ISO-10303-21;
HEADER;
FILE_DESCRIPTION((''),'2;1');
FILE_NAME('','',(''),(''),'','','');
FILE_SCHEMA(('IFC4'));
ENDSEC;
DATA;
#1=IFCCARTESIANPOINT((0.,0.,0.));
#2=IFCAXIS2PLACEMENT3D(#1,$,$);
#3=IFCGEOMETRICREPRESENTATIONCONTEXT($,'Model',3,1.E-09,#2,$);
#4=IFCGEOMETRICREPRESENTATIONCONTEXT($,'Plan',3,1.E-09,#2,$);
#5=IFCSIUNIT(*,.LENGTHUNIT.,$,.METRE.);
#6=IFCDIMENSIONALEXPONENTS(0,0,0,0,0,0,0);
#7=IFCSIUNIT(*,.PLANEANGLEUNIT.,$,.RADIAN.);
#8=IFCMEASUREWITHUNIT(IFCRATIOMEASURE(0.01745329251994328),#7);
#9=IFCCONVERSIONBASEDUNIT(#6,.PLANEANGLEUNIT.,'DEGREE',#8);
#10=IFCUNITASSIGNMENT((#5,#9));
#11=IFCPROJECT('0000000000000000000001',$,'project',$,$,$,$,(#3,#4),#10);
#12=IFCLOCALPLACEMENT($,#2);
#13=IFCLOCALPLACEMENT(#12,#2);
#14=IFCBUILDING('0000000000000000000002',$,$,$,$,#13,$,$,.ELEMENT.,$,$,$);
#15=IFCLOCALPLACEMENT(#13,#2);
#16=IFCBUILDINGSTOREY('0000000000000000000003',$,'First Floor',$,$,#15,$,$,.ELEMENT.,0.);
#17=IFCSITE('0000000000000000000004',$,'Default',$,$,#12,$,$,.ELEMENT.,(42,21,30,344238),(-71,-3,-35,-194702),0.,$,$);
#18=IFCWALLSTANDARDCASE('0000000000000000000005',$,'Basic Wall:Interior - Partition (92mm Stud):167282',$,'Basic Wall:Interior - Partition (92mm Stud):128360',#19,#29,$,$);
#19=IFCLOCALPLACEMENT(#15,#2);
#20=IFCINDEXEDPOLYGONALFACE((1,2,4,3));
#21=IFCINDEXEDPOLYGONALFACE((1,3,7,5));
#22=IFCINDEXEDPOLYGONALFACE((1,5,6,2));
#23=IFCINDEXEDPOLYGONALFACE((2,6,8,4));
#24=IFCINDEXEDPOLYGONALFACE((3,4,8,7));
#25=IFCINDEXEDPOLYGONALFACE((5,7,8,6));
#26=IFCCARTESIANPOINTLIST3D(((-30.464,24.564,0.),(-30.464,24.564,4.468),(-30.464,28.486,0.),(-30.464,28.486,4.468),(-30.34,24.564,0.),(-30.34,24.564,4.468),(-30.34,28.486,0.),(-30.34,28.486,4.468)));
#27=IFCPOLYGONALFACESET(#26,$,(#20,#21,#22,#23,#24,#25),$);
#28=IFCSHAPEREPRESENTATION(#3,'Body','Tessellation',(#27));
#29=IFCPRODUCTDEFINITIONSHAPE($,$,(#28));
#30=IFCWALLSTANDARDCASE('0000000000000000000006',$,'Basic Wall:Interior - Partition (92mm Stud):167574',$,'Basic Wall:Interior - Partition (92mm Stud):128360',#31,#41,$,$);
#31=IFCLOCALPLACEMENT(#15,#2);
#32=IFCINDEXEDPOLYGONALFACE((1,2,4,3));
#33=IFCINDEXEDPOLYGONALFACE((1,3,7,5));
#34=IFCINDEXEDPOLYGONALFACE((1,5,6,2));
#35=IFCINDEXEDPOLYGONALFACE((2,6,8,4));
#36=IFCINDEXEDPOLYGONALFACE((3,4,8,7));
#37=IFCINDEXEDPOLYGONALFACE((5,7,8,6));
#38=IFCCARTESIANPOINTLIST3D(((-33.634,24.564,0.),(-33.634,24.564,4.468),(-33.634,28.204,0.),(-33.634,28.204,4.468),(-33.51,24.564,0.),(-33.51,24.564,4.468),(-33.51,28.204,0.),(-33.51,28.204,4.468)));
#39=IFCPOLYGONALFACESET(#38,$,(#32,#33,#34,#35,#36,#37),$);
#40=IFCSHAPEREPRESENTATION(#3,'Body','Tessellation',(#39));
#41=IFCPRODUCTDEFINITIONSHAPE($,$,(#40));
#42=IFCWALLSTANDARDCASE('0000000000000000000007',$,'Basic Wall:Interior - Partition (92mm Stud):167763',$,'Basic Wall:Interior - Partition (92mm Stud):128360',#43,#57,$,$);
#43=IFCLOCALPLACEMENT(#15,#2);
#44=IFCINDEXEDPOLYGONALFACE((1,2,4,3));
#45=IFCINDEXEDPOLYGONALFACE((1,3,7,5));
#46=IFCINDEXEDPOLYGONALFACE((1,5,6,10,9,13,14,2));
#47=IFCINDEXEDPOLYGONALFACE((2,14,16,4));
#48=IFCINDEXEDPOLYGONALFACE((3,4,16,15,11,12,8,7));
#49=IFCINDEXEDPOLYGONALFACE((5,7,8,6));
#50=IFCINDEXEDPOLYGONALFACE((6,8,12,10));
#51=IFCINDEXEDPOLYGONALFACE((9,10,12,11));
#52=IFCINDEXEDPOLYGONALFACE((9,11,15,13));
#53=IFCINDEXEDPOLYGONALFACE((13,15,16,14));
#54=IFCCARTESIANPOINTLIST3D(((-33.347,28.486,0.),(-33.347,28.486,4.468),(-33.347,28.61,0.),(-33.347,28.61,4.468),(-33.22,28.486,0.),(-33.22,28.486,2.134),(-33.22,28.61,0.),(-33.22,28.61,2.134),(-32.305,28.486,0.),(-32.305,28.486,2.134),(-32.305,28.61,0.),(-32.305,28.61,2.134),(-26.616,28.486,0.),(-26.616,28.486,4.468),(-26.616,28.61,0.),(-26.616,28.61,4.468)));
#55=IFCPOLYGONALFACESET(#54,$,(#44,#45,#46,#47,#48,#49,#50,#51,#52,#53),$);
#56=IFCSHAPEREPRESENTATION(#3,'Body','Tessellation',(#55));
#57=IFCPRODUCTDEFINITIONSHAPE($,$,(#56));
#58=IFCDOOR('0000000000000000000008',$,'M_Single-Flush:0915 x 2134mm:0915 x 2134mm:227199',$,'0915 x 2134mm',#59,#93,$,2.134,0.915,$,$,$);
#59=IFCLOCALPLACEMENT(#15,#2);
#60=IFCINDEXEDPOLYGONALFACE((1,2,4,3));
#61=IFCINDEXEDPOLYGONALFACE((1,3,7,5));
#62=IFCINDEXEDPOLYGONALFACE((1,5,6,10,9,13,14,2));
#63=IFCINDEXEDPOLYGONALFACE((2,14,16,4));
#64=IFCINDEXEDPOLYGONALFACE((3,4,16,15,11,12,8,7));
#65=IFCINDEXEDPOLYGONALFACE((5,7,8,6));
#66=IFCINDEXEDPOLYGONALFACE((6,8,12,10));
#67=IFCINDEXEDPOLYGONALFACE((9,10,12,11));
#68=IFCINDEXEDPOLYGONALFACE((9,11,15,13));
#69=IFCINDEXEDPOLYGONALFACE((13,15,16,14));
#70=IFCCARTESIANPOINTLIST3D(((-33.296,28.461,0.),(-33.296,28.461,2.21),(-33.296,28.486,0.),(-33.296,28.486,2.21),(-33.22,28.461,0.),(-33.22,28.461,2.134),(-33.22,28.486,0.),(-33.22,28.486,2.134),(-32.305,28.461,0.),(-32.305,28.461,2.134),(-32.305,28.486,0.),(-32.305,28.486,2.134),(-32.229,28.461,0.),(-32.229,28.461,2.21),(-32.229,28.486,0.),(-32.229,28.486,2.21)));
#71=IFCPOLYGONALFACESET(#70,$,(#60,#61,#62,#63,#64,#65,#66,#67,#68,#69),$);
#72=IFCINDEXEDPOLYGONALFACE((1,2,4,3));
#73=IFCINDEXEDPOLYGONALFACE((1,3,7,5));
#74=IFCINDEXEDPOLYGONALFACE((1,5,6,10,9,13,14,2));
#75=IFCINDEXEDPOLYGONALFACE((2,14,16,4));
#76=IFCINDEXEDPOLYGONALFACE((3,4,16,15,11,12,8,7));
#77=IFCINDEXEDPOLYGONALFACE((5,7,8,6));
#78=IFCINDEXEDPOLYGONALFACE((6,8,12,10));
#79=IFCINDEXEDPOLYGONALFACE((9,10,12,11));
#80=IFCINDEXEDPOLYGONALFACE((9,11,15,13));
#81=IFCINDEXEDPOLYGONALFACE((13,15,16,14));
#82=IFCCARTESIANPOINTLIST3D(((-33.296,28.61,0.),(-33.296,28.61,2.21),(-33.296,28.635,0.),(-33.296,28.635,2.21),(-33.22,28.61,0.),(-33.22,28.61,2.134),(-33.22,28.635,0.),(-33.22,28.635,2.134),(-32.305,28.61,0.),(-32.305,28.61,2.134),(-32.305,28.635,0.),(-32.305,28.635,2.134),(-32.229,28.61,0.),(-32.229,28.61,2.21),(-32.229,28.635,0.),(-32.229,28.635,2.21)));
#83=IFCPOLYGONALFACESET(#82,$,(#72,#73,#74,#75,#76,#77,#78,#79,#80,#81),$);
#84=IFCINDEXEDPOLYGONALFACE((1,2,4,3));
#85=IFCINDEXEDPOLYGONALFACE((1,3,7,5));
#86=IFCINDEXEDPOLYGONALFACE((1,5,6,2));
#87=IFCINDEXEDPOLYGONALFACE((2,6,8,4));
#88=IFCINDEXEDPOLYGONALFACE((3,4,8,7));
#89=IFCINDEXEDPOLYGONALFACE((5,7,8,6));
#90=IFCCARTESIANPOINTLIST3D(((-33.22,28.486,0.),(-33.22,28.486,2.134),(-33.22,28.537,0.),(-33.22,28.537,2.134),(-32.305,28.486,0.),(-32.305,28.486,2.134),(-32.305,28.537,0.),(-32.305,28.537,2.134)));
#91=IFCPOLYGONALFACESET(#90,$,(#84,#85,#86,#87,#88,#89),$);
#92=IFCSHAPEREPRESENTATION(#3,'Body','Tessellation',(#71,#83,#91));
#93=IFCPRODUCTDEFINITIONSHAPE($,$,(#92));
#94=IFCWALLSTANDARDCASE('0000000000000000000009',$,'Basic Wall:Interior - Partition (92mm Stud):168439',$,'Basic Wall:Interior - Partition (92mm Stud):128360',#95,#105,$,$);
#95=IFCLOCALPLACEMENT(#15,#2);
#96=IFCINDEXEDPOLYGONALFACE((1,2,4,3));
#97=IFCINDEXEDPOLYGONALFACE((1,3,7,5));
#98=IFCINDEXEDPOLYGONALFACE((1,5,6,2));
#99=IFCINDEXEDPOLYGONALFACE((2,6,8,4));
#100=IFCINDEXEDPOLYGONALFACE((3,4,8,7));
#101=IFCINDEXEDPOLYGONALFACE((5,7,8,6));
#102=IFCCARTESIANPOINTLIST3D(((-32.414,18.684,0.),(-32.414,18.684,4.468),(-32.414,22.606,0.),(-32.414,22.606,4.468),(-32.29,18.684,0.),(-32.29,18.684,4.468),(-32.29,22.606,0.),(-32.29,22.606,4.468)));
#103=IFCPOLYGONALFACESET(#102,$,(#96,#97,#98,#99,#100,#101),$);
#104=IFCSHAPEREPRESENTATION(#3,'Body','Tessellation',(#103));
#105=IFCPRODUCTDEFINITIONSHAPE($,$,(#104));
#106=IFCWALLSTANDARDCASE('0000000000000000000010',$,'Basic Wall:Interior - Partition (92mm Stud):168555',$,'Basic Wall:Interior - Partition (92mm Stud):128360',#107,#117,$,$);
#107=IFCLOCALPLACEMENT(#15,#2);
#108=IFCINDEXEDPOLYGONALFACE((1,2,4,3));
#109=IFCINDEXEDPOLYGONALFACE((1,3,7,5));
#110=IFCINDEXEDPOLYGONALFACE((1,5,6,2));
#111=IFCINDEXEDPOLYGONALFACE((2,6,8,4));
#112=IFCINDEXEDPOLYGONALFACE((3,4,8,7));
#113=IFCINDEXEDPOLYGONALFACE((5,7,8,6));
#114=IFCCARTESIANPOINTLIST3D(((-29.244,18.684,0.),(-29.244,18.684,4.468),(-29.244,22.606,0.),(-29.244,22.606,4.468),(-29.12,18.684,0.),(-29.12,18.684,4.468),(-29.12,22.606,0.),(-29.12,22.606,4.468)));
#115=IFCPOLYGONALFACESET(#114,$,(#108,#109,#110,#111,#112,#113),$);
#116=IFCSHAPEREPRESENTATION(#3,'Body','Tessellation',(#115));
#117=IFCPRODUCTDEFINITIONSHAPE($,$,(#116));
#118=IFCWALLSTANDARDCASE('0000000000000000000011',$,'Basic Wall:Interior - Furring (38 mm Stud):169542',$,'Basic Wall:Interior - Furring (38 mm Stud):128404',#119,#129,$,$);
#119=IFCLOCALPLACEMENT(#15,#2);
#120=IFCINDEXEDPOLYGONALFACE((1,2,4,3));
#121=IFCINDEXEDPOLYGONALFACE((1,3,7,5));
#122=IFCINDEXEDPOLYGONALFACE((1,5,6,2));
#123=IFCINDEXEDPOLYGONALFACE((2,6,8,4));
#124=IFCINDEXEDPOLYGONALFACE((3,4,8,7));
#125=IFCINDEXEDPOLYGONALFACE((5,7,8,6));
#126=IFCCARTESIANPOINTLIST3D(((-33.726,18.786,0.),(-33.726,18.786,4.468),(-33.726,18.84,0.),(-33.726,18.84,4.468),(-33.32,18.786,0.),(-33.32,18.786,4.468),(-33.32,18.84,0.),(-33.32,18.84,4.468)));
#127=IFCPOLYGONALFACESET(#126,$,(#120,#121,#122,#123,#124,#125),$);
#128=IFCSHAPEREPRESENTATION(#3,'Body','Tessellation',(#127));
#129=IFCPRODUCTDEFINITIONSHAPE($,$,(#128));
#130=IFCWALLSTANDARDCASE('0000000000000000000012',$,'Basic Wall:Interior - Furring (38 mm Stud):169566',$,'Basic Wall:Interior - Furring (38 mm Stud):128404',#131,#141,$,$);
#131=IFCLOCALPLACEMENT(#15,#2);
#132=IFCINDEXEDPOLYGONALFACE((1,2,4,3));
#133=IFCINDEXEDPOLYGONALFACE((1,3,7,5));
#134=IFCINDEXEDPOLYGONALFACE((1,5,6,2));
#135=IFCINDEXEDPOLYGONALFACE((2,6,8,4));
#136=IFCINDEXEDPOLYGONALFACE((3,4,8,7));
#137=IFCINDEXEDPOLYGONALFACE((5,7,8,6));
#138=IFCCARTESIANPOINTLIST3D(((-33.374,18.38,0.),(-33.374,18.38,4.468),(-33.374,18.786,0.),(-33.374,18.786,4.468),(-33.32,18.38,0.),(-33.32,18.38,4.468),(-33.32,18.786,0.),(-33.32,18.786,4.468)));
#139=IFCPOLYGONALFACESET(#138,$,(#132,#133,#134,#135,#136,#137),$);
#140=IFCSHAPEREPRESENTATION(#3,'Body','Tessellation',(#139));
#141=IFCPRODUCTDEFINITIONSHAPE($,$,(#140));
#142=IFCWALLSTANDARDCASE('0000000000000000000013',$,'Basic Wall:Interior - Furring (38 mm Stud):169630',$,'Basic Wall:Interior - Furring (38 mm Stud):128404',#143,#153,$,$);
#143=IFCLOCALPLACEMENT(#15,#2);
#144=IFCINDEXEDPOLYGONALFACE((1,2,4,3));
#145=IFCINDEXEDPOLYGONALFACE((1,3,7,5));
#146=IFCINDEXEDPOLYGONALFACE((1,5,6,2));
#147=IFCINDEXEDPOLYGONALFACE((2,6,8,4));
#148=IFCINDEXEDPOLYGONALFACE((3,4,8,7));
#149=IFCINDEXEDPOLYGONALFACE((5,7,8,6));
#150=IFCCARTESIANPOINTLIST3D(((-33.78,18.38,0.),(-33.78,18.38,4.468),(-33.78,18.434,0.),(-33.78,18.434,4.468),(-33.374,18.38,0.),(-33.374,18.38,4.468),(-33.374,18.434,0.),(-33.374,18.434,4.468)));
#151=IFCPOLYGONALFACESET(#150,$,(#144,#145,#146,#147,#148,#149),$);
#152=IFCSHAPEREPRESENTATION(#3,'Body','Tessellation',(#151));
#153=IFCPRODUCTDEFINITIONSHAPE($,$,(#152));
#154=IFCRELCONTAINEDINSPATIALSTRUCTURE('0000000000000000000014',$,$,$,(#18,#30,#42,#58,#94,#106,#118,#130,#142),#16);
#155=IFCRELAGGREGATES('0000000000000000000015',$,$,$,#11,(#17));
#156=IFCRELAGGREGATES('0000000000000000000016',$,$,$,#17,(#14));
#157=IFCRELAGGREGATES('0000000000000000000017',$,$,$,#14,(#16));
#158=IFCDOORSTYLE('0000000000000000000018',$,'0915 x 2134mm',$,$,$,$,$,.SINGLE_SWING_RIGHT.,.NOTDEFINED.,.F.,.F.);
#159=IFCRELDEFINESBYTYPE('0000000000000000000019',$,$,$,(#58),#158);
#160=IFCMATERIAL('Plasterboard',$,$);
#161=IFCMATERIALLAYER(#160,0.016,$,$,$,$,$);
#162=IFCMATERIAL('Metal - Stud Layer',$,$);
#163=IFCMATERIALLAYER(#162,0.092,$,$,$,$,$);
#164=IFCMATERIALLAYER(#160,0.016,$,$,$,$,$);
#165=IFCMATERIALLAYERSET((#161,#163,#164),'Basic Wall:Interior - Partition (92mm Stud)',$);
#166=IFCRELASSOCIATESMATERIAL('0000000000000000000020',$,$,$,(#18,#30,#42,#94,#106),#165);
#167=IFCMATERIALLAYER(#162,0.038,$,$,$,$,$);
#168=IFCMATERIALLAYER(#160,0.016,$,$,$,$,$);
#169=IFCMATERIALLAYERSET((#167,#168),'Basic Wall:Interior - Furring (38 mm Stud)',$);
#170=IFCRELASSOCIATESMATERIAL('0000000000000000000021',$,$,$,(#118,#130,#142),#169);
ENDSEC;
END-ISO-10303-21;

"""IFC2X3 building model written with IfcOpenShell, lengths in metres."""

from ifc_helpers import new_model, entity, si_unit, converted_unit, frame, frame_2d, origin, origin_2d_with_axis, place, context, project, spatial, polyline, rectangle, outline, extrude, source, transform, mapped, material, layer, layer_set, layer_usage, type_object, type_shapes, element, fill, save


model = new_model("IFC2X3")

# Units and contexts
model_context = context("Model", 3, precision=1e-09, world=origin())
plan_context = context("Plan", 3, precision=1e-09, world=origin())
ifc_project = project(units=[si_unit("LENGTHUNIT", "METRE"), converted_unit("PLANEANGLEUNIT", "DEGREE", entity("IfcRatioMeasure", 0.01745329251994328), si_unit("PLANEANGLEUNIT", "RADIAN"), dimensions=[0, 0, 0, 0, 0, 0, 0])], contexts=[model_context, plan_context])

# Site, building, storey
site_placement = place(None, origin())
site = spatial("IfcSite", under=ifc_project, at=site_placement, Name="Default", CompositionType="ELEMENT", RefLatitude=(42, 21, 30, 344238), RefLongitude=(-71, -3, -35, -194702), RefElevation=0.0)
building_placement = place(site_placement, origin())
building = spatial("IfcBuilding", under=site, at=building_placement, CompositionType="ELEMENT")
storey_placement = place(building_placement, origin())
storey = spatial("IfcBuildingStorey", under=building, at=storey_placement, Name="First Floor", CompositionType="ELEMENT", Elevation=0.0)

# Walls
ifc_material_1 = material(Name="Plasterboard")
ifc_layer_1 = layer(ifc_material_1, 0.016)
ifc_material_2 = material(Name="Metal - Stud Layer")
ifc_layer_2 = layer(ifc_material_2, 0.092)
ifc_layer_3 = layer(ifc_material_1, 0.016)
ifc_layer_set_1 = layer_set([ifc_layer_1, ifc_layer_2, ifc_layer_3], Name="Basic Wall:Interior - Partition (92mm Stud)")
ifc_layer_usage_1 = layer_usage(ifc_layer_set_1, "AXIS2", "NEGATIVE", 0.062)
wall_1_placement = place(storey_placement, frame((-30.402, 28.486, 0.0), z_axis=(0.0, 0.0, 1.0), x_axis=(0.0, -1.0, 0.0)))
element("IfcWallStandardCase", 1, at=wall_1_placement, inside=storey, material=ifc_layer_usage_1, Name="Basic Wall:Interior - Partition (92mm Stud):167282", ObjectType="Basic Wall:Interior - Partition (92mm Stud):128360", context=model_context, shape_type="SweptSolid", body=[
    extrude(rectangle(XDim=3.922, YDim=0.124, at=frame_2d((1.961, 0.0), x_axis=(-1.0, 0.0))), origin(), (0.0, 0.0, 1.0), 4.468),
])
ifc_layer_usage_2 = layer_usage(ifc_layer_set_1, "AXIS2", "NEGATIVE", 0.062)
wall_2_placement = place(storey_placement, frame((-33.572, 28.204, 0.0), z_axis=(0.0, 0.0, 1.0), x_axis=(0.0, -1.0, 0.0)))
element("IfcWallStandardCase", 2, at=wall_2_placement, inside=storey, material=ifc_layer_usage_2, Name="Basic Wall:Interior - Partition (92mm Stud):167574", ObjectType="Basic Wall:Interior - Partition (92mm Stud):128360", context=model_context, shape_type="SweptSolid", body=[
    extrude(rectangle(XDim=3.64, YDim=0.124, at=frame_2d((1.82, 0.0), x_axis=(-1.0, 0.0))), origin(), (0.0, 0.0, 1.0), 4.468),
])

# Wall, opening, door
ifc_layer_usage_3 = layer_usage(ifc_layer_set_1, "AXIS2", "NEGATIVE", 0.062)
wall_3_placement = place(storey_placement, frame((-33.347, 28.548, 0.0)))
wall_3 = element("IfcWallStandardCase", 3, at=wall_3_placement, inside=storey, material=ifc_layer_usage_3, Name="Basic Wall:Interior - Partition (92mm Stud):167763", ObjectType="Basic Wall:Interior - Partition (92mm Stud):128360", context=model_context, shape_type="SweptSolid", body=[
    extrude(rectangle(XDim=6.731, YDim=0.124, at=frame_2d((3.3655, 0.0), x_axis=(-1.0, 0.0))), origin(), (0.0, 0.0, 1.0), 4.468),
])
opening_1_placement = place(wall_3_placement, frame((1.042, 0.062, 0.0)))
opening_1 = element("IfcOpeningElement", 4, at=opening_1_placement, cuts=wall_3, ObjectType="Opening", context=model_context, shape_type="SweptSolid", body=[
    extrude(rectangle(XDim=0.915, YDim=2.134, at=frame_2d((1.067, 0.4575), x_axis=(0.0, 1.0))), frame((0.0, 0.0, 0.0), z_axis=(0.0, -1.0, 0.0), x_axis=(0.0, 0.0, 1.0)), (0.0, 0.0, 1.0), 0.124),
])
door_style_1 = type_object("IfcDoorStyle", Name="0915 x 2134mm", ConstructionType="NOTDEFINED", OperationType="SINGLE_SWING_RIGHT", ParameterTakesPrecedence=False, Sizeable=False)
shared_shape_1 = source(origin(), model_context, "Body", "SweptSolid", [
    extrude(outline(polyline([(-0.5335, -1.124), (0.5335, -1.124), (0.5335, 1.086), (0.4575, 1.086), (0.4575, -1.048), (-0.4575, -1.048), (-0.4575, 1.086), (-0.5335, 1.086), (-0.5335, -1.124)])), frame((0.4575, 0.124, 1.086), z_axis=(0.0, 1.0, 0.0), x_axis=(1.0, 0.0, 0.0)), (0.0, 0.0, 1.0), 0.025),
    extrude(outline(polyline([(-1.124, -0.5335), (1.086, -0.5335), (1.086, -0.4575), (-1.048, -0.4575), (-1.048, 0.4575), (1.086, 0.4575), (1.086, 0.5335), (-1.124, 0.5335), (-1.124, -0.5335)])), frame((0.4575, -0.025, 1.086), z_axis=(0.0, 1.0, 0.0), x_axis=(0.0, 0.0, -1.0)), (0.0, 0.0, 1.0), 0.025),
    extrude(rectangle(XDim=0.051, YDim=0.915, at=origin_2d_with_axis()), frame((0.4575, 0.0985, 0.0), z_axis=(0.0, 0.0, 1.0), x_axis=(0.0, 1.0, 0.0)), (0.0, 0.0, 1.0), 2.134),
])
type_shapes(door_style_1, [shared_shape_1])
door_1_placement = place(opening_1_placement, frame((0.0, 0.0, 0.0), z_axis=(0.0, 0.0, 1.0), x_axis=(-1.0, 0.0, 0.0)))
door_1 = element("IfcDoor", 5, at=door_1_placement, inside=storey, type_object=door_style_1, Name="M_Single-Flush:0915 x 2134mm:0915 x 2134mm:227199", ObjectType="0915 x 2134mm", OverallHeight=2.134, OverallWidth=0.915, context=model_context, shape_type="MappedRepresentation", body=[
    mapped(shared_shape_1, transform((0.0, 0.0, 0.0), scale=1.0)),
])
fill(opening_1, door_1)

# Walls
ifc_layer_usage_4 = layer_usage(ifc_layer_set_1, "AXIS2", "NEGATIVE", 0.062)
wall_4_placement = place(storey_placement, frame((-32.352, 22.606, 0.0), z_axis=(0.0, 0.0, 1.0), x_axis=(0.0, -1.0, 0.0)))
element("IfcWallStandardCase", 6, at=wall_4_placement, inside=storey, material=ifc_layer_usage_4, Name="Basic Wall:Interior - Partition (92mm Stud):168439", ObjectType="Basic Wall:Interior - Partition (92mm Stud):128360", context=model_context, shape_type="SweptSolid", body=[
    extrude(rectangle(XDim=3.922, YDim=0.124, at=frame_2d((1.961, 0.0), x_axis=(-1.0, 0.0))), origin(), (0.0, 0.0, 1.0), 4.468),
])
ifc_layer_usage_5 = layer_usage(ifc_layer_set_1, "AXIS2", "NEGATIVE", 0.062)
wall_5_placement = place(storey_placement, frame((-29.182, 22.606, 0.0), z_axis=(0.0, 0.0, 1.0), x_axis=(0.0, -1.0, 0.0)))
element("IfcWallStandardCase", 7, at=wall_5_placement, inside=storey, material=ifc_layer_usage_5, Name="Basic Wall:Interior - Partition (92mm Stud):168555", ObjectType="Basic Wall:Interior - Partition (92mm Stud):128360", context=model_context, shape_type="SweptSolid", body=[
    extrude(rectangle(XDim=3.922, YDim=0.124, at=frame_2d((1.961, 0.0), x_axis=(-1.0, 0.0))), origin(), (0.0, 0.0, 1.0), 4.468),
])
ifc_layer_4 = layer(ifc_material_2, 0.038)
ifc_layer_5 = layer(ifc_material_1, 0.016)
ifc_layer_set_2 = layer_set([ifc_layer_4, ifc_layer_5], Name="Basic Wall:Interior - Furring (38 mm Stud)")
ifc_layer_usage_6 = layer_usage(ifc_layer_set_2, "AXIS2", "POSITIVE", -0.027)
wall_6_placement = place(storey_placement, frame((-33.726, 18.813, 0.0)))
element("IfcWallStandardCase", 8, at=wall_6_placement, inside=storey, material=ifc_layer_usage_6, Name="Basic Wall:Interior - Furring (38 mm Stud):169542", ObjectType="Basic Wall:Interior - Furring (38 mm Stud):128404", context=model_context, shape_type="SweptSolid", body=[
    extrude(rectangle(XDim=0.406, YDim=0.054, at=frame_2d((0.203, 0.0), x_axis=(-1.0, 0.0))), origin(), (0.0, 0.0, 1.0), 4.468),
])
ifc_layer_usage_7 = layer_usage(ifc_layer_set_2, "AXIS2", "POSITIVE", -0.027)
wall_7_placement = place(storey_placement, frame((-33.347, 18.786, 0.0), z_axis=(0.0, 0.0, 1.0), x_axis=(0.0, -1.0, 0.0)))
element("IfcWallStandardCase", 9, at=wall_7_placement, inside=storey, material=ifc_layer_usage_7, Name="Basic Wall:Interior - Furring (38 mm Stud):169566", ObjectType="Basic Wall:Interior - Furring (38 mm Stud):128404", context=model_context, shape_type="SweptSolid", body=[
    extrude(rectangle(XDim=0.406, YDim=0.054, at=frame_2d((0.203, 0.0), x_axis=(-1.0, 0.0))), origin(), (0.0, 0.0, 1.0), 4.468),
])
ifc_layer_usage_8 = layer_usage(ifc_layer_set_2, "AXIS2", "POSITIVE", -0.027)
wall_8_placement = place(storey_placement, frame((-33.374, 18.407, 0.0), z_axis=(0.0, 0.0, 1.0), x_axis=(-1.0, 0.0, 0.0)))
element("IfcWallStandardCase", 10, at=wall_8_placement, inside=storey, material=ifc_layer_usage_8, Name="Basic Wall:Interior - Furring (38 mm Stud):169630", ObjectType="Basic Wall:Interior - Furring (38 mm Stud):128404", context=model_context, shape_type="SweptSolid", body=[
    extrude(rectangle(XDim=0.406, YDim=0.054, at=frame_2d((0.203, 0.0), x_axis=(-1.0, 0.0))), origin(), (0.0, 0.0, 1.0), 4.468),
])

save(model, "model.ifc")
